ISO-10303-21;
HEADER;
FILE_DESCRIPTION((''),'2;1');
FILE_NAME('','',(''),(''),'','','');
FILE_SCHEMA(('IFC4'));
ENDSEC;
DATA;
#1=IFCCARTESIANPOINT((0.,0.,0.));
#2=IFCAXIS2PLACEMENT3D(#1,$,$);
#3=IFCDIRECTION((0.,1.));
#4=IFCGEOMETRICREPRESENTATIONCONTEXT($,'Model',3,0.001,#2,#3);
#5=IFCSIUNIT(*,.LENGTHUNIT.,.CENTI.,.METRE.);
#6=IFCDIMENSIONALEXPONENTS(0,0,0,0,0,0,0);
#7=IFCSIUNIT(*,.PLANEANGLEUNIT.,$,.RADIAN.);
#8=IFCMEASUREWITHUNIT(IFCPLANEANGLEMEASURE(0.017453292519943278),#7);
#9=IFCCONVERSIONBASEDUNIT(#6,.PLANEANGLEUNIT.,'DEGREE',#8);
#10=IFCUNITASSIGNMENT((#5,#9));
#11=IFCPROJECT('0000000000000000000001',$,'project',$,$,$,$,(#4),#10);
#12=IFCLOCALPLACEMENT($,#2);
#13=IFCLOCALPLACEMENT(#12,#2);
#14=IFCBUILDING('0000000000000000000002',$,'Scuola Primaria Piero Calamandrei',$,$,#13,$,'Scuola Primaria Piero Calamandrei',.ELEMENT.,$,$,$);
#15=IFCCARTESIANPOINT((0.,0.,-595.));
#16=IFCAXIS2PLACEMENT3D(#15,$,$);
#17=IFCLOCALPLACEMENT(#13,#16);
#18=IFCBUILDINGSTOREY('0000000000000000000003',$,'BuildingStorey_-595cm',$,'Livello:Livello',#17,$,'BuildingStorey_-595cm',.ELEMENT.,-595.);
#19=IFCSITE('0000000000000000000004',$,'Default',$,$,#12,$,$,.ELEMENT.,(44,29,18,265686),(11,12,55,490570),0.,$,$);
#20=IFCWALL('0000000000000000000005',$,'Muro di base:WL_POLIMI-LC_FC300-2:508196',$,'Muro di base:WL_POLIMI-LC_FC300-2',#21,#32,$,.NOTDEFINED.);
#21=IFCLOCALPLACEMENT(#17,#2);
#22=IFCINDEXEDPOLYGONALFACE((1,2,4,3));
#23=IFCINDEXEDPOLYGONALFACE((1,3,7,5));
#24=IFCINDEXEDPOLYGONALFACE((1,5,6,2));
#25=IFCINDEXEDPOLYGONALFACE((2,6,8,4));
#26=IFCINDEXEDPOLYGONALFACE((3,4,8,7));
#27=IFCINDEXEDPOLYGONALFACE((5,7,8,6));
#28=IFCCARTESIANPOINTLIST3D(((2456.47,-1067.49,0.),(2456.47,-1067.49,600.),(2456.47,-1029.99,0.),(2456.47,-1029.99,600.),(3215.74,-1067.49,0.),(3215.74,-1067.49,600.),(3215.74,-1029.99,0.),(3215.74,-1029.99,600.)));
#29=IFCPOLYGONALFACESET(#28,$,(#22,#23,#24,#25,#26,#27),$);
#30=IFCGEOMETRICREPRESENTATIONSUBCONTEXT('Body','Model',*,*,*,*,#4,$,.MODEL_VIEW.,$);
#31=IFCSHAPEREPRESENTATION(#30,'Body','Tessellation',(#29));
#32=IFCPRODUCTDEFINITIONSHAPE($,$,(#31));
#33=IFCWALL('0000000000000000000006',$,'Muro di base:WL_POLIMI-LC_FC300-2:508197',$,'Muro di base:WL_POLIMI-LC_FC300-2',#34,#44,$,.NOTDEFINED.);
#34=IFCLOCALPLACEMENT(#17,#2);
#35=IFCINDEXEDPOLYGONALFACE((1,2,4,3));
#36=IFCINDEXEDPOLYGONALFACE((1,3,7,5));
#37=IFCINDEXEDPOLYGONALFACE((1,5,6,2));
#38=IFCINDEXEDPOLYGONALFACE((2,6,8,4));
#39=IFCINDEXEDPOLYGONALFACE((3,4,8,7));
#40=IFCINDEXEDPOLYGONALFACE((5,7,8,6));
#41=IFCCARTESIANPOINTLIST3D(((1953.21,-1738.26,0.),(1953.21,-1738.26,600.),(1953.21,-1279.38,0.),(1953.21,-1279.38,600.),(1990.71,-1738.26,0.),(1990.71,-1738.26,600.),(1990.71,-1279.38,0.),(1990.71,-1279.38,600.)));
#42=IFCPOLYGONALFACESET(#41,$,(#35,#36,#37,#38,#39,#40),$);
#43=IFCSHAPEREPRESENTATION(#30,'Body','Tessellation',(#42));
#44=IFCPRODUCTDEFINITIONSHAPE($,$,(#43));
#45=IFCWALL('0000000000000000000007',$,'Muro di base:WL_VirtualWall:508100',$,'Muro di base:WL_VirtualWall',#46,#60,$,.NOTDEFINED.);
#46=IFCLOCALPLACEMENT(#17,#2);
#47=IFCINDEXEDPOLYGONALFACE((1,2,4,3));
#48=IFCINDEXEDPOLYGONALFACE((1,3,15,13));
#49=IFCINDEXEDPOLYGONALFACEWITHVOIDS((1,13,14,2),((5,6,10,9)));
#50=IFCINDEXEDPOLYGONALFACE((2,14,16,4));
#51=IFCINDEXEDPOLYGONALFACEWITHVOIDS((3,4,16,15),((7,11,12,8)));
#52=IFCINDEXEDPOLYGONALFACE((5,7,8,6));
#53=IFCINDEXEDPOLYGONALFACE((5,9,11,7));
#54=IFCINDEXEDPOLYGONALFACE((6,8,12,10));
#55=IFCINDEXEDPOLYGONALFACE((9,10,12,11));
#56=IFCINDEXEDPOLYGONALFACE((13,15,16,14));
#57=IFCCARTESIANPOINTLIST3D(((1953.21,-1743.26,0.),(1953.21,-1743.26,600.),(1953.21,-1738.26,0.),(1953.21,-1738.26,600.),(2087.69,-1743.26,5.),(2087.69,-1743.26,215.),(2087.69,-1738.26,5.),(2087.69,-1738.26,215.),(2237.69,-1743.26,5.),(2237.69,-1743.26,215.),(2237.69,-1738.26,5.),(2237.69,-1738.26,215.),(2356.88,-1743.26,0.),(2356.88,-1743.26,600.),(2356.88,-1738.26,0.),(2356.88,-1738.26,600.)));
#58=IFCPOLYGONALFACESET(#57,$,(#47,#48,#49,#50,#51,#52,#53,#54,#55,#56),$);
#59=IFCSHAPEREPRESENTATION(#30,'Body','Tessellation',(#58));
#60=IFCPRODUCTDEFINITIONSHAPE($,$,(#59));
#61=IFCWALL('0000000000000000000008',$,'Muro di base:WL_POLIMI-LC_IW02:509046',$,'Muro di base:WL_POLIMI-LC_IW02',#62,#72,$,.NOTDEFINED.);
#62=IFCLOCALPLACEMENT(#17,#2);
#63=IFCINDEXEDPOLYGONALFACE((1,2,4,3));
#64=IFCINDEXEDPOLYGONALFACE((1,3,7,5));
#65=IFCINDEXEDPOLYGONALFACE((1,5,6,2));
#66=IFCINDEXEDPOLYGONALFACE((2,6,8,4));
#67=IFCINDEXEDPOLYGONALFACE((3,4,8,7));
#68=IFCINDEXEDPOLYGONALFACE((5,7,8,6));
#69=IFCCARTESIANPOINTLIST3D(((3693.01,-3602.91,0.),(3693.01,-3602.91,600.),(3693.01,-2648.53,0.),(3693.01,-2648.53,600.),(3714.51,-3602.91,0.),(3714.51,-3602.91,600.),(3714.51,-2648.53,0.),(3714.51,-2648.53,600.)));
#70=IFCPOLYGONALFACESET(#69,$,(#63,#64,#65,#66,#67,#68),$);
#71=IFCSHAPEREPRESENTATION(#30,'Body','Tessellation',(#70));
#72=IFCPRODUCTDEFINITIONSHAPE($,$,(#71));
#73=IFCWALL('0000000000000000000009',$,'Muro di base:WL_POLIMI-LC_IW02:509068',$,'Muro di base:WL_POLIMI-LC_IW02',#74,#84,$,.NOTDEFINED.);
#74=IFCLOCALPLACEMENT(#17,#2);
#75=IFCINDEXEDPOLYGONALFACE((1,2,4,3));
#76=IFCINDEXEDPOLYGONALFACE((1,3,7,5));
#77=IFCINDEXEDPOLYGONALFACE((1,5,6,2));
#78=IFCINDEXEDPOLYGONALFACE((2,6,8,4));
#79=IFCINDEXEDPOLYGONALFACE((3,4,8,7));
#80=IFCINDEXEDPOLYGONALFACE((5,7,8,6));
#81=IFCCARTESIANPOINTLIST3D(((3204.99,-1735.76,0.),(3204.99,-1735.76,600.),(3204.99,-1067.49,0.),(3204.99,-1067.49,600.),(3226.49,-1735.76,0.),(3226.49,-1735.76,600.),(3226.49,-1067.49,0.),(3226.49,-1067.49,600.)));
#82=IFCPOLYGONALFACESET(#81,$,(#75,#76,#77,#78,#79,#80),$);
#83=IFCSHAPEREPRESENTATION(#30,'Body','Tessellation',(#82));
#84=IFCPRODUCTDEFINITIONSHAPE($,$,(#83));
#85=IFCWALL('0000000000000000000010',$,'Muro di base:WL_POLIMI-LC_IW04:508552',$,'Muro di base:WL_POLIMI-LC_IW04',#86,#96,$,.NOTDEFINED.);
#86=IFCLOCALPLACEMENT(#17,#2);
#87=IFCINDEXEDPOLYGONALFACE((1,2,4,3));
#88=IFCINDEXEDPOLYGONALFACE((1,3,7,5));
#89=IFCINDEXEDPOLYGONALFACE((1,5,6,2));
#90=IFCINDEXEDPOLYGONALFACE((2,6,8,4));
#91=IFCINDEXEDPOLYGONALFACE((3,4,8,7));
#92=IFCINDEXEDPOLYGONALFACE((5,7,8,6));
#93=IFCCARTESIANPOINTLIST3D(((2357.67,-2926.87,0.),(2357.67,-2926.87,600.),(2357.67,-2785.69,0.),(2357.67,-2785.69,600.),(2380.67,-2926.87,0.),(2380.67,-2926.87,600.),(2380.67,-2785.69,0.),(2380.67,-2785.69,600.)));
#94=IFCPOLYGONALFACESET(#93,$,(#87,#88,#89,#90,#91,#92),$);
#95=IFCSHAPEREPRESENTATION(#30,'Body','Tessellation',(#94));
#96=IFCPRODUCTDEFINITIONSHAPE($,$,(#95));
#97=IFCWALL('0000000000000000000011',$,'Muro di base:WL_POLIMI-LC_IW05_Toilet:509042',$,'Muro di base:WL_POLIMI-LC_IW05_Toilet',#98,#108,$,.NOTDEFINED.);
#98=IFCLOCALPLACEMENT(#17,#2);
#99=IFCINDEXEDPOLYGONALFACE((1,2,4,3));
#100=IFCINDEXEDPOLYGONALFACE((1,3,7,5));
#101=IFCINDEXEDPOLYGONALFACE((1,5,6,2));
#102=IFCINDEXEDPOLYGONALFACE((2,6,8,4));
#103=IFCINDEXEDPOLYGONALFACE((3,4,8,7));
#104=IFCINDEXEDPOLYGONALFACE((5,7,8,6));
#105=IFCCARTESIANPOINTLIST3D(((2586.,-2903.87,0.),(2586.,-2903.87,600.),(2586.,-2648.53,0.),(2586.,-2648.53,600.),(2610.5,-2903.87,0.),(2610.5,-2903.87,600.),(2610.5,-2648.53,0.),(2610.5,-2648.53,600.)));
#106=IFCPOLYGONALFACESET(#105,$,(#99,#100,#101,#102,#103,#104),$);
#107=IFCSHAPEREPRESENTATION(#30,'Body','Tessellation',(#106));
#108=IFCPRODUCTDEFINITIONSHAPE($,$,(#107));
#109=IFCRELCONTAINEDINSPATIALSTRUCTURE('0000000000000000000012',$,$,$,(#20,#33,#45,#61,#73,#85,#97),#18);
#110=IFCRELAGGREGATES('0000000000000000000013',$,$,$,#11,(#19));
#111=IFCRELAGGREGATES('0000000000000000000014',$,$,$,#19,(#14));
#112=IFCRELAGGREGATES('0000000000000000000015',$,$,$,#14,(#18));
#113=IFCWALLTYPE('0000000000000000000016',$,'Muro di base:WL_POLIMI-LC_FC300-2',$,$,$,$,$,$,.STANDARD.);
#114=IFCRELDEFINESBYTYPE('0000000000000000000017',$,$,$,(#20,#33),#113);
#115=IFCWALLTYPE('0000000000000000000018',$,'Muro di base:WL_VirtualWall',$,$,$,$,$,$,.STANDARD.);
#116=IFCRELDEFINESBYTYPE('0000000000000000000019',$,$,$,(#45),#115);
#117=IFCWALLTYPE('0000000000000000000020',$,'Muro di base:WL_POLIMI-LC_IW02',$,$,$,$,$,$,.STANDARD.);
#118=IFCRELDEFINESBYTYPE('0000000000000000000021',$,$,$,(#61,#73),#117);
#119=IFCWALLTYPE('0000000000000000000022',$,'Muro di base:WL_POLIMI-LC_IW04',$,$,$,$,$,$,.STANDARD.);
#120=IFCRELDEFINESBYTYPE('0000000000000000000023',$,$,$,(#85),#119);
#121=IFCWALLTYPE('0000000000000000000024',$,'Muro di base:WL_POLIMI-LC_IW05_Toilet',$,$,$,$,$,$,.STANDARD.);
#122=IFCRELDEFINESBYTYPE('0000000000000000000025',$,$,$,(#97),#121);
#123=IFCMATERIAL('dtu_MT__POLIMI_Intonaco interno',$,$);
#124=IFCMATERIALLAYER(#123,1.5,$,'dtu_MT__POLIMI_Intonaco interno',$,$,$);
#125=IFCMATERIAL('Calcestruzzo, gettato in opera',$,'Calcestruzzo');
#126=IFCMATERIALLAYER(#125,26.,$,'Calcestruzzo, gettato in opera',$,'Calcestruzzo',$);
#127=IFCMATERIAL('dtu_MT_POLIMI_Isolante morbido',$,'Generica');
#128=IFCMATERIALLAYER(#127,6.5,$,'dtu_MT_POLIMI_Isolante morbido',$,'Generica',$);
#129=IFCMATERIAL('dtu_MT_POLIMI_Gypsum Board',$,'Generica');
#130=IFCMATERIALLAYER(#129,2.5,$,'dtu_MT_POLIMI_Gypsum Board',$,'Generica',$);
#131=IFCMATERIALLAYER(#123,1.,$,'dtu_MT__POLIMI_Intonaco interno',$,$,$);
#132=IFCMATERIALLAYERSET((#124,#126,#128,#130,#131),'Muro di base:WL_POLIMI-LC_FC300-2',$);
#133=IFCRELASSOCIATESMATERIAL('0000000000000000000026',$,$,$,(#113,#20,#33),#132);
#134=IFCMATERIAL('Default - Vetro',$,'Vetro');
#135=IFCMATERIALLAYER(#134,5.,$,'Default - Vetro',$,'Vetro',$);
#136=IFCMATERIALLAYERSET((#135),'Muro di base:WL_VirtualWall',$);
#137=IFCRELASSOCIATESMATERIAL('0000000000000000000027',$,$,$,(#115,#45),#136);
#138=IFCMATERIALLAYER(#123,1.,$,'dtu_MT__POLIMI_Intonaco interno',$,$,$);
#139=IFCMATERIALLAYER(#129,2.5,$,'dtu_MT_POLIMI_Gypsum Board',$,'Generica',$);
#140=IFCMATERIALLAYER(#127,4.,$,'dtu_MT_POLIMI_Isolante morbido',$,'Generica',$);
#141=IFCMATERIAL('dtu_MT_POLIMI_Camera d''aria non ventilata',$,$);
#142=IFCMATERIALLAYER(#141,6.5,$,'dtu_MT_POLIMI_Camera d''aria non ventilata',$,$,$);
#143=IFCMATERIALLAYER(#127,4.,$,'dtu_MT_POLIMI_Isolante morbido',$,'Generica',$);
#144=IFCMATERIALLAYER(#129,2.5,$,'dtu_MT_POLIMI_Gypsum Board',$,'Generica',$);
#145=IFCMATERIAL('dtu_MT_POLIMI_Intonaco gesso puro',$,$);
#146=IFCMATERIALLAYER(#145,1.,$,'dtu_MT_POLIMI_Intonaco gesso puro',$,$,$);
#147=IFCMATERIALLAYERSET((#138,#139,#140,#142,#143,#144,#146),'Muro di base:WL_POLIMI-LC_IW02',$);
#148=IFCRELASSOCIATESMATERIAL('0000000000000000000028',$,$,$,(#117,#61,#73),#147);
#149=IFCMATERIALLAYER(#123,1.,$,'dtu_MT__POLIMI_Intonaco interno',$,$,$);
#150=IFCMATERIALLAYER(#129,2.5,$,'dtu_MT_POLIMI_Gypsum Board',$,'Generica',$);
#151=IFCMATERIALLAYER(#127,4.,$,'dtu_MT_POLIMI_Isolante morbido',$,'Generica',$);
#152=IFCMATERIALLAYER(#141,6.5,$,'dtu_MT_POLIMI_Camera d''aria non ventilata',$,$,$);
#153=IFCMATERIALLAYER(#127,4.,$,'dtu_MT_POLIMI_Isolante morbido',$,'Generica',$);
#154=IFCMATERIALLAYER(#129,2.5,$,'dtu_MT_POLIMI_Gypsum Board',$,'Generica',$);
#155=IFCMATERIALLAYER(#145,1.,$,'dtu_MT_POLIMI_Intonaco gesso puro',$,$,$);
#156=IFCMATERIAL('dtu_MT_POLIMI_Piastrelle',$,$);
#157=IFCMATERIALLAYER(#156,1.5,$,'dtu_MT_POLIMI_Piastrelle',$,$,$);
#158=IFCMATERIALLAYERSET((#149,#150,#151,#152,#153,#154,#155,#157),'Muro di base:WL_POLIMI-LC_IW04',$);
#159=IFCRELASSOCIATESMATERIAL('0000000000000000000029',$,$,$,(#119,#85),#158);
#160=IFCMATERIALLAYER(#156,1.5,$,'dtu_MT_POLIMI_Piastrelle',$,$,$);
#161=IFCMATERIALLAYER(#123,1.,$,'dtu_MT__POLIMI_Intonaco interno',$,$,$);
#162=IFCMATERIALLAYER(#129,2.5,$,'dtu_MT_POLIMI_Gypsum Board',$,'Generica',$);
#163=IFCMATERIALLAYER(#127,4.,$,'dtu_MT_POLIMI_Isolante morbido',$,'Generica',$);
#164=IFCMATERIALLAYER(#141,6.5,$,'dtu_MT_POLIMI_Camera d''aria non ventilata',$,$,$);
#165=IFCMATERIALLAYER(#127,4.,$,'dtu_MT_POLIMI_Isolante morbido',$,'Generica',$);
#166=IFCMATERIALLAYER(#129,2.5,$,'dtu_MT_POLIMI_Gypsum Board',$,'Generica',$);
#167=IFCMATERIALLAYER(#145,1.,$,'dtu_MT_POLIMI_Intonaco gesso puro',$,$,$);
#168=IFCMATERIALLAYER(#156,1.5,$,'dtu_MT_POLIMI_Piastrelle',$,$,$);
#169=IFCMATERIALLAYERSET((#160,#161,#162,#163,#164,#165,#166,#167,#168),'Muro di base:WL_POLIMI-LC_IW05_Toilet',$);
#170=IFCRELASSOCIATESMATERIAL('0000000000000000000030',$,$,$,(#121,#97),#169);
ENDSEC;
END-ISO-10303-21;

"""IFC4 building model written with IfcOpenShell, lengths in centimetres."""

from ifc_helpers import new_model, entity, si_unit, converted_unit, direction, frame, frame_2d, origin, place, context, subcontext, project, spatial, rectangle, extrude, material, layer, layer_set, layer_usage, type_object, element, save


model = new_model("IFC4")

# Units and contexts
model_context = context("Model", 3, precision=0.001, world=origin(), true_north=direction((0.0, 1.0)))
body_context = subcontext(model_context, "Body", "Model", "MODEL_VIEW")
ifc_project = project(units=[si_unit("LENGTHUNIT", "METRE", prefix="CENTI"), converted_unit("PLANEANGLEUNIT", "DEGREE", entity("IfcPlaneAngleMeasure", 0.017453292519943278), si_unit("PLANEANGLEUNIT", "RADIAN"), dimensions=[0, 0, 0, 0, 0, 0, 0])], contexts=[model_context])

# Site, building, storey
site_placement = place(None, origin())
site = spatial("IfcSite", under=ifc_project, at=site_placement, Name="Default", CompositionType="ELEMENT", RefLatitude=(44, 29, 18, 265686), RefLongitude=(11, 12, 55, 490570), RefElevation=0.0)
building_placement = place(site_placement, origin())
building = spatial("IfcBuilding", under=site, at=building_placement, Name="Scuola Primaria Piero Calamandrei", LongName="Scuola Primaria Piero Calamandrei", CompositionType="ELEMENT")
storey_placement = place(building_placement, frame((0.0, 0.0, -595.0)))
storey = spatial("IfcBuildingStorey", under=building, at=storey_placement, Name="BuildingStorey_-595cm", ObjectType="Livello:Livello", LongName="BuildingStorey_-595cm", CompositionType="ELEMENT", Elevation=-595.0)

# Shared definitions
ifc_material_1 = material(Name="Default - Vetro", Category="Vetro")

# Walls
ifc_material_2 = material(Name="dtu_MT__POLIMI_Intonaco interno")
ifc_layer_1 = layer(ifc_material_2, 1.5, Name="dtu_MT__POLIMI_Intonaco interno")
ifc_material_3 = material(Name="Calcestruzzo, gettato in opera", Category="Calcestruzzo")
ifc_layer_2 = layer(ifc_material_3, 26.0, Name="Calcestruzzo, gettato in opera", Category="Calcestruzzo")
ifc_material_4 = material(Name="dtu_MT_POLIMI_Isolante morbido", Category="Generica")
ifc_layer_3 = layer(ifc_material_4, 6.5, Name="dtu_MT_POLIMI_Isolante morbido", Category="Generica")
ifc_material_5 = material(Name="dtu_MT_POLIMI_Gypsum Board", Category="Generica")
ifc_layer_4 = layer(ifc_material_5, 2.5, Name="dtu_MT_POLIMI_Gypsum Board", Category="Generica")
ifc_layer_5 = layer(ifc_material_2, 1.0, Name="dtu_MT__POLIMI_Intonaco interno")
ifc_layer_set_1 = layer_set([ifc_layer_1, ifc_layer_2, ifc_layer_3, ifc_layer_4, ifc_layer_5], Name="Muro di base:WL_POLIMI-LC_FC300-2")
wall_type_1 = type_object("IfcWallType", Name="Muro di base:WL_POLIMI-LC_FC300-2", PredefinedType="STANDARD", material=ifc_layer_set_1)
ifc_layer_usage_1 = layer_usage(ifc_layer_set_1, "AXIS2", "NEGATIVE", 18.75)
wall_1_placement = place(storey_placement, frame((2456.47, -1048.74, 0.0)))
element("IfcWall", 1, at=wall_1_placement, inside=storey, type_object=wall_type_1, material=ifc_layer_usage_1, Name="Muro di base:WL_POLIMI-LC_FC300-2:508196", ObjectType="Muro di base:WL_POLIMI-LC_FC300-2", PredefinedType="NOTDEFINED", context=body_context, shape_type="SweptSolid", body=[
    extrude(rectangle(XDim=759.27, YDim=37.5, at=frame_2d((379.63, 0.0), x_axis=(-1.0, 0.0))), origin(), (0.0, 0.0, 1.0), 600.0),
])
ifc_layer_usage_2 = layer_usage(ifc_layer_set_1, "AXIS2", "NEGATIVE", 18.75)
wall_2_placement = place(storey_placement, frame((1971.96, -1279.38, 0.0), z_axis=(0.0, 0.0, 1.0), x_axis=(0.0, -1.0, 0.0)))
element("IfcWall", 2, at=wall_2_placement, inside=storey, type_object=wall_type_1, material=ifc_layer_usage_2, Name="Muro di base:WL_POLIMI-LC_FC300-2:508197", ObjectType="Muro di base:WL_POLIMI-LC_FC300-2", PredefinedType="NOTDEFINED", context=body_context, shape_type="SweptSolid", body=[
    extrude(rectangle(XDim=458.88, YDim=37.5, at=frame_2d((229.44, 0.0), x_axis=(-1.0, 0.0))), origin(), (0.0, 0.0, 1.0), 600.0),
])

# Wall, opening
ifc_layer_6 = layer(ifc_material_1, 5.0, Name="Default - Vetro", Category="Vetro")
ifc_layer_set_2 = layer_set([ifc_layer_6], Name="Muro di base:WL_VirtualWall")
ifc_layer_usage_3 = layer_usage(ifc_layer_set_2, "AXIS2", "NEGATIVE", 2.5)
wall_type_2 = type_object("IfcWallType", Name="Muro di base:WL_VirtualWall", PredefinedType="STANDARD", material=ifc_layer_set_2)
wall_3_placement = place(storey_placement, frame((1953.21, -1740.76, 0.0)))
wall_3 = element("IfcWall", 3, at=wall_3_placement, inside=storey, type_object=wall_type_2, material=ifc_layer_usage_3, Name="Muro di base:WL_VirtualWall:508100", ObjectType="Muro di base:WL_VirtualWall", PredefinedType="NOTDEFINED", context=body_context, shape_type="SweptSolid", body=[
    extrude(rectangle(XDim=403.67, YDim=5.0, at=frame_2d((201.83, 0.0), x_axis=(-1.0, 0.0))), origin(), (0.0, 0.0, 1.0), 600.0),
])
opening_1_placement = place(wall_3_placement, frame((284.48, 2.5, 5.0)))
element("IfcOpeningElement", 4, at=opening_1_placement, cuts=wall_3, PredefinedType="OPENING", context=body_context, shape_type="SweptSolid", body=[
    extrude(rectangle(XDim=210.0, YDim=150.0, at=frame_2d((105.0, 75.0), x_axis=(-1.0, 0.0))), frame((0.0, 0.0, 0.0), z_axis=(0.0, -1.0, 0.0), x_axis=(0.0, 0.0, 1.0)), (0.0, 0.0, 1.0), 5.0),
])

# Walls
ifc_layer_7 = layer(ifc_material_2, 1.0, Name="dtu_MT__POLIMI_Intonaco interno")
ifc_layer_8 = layer(ifc_material_5, 2.5, Name="dtu_MT_POLIMI_Gypsum Board", Category="Generica")
ifc_layer_9 = layer(ifc_material_4, 4.0, Name="dtu_MT_POLIMI_Isolante morbido", Category="Generica")
ifc_material_6 = material(Name="dtu_MT_POLIMI_Camera d'aria non ventilata")
ifc_layer_10 = layer(ifc_material_6, 6.5, Name="dtu_MT_POLIMI_Camera d'aria non ventilata")
ifc_layer_11 = layer(ifc_material_4, 4.0, Name="dtu_MT_POLIMI_Isolante morbido", Category="Generica")
ifc_layer_12 = layer(ifc_material_5, 2.5, Name="dtu_MT_POLIMI_Gypsum Board", Category="Generica")
ifc_material_7 = material(Name="dtu_MT_POLIMI_Intonaco gesso puro")
ifc_layer_13 = layer(ifc_material_7, 1.0, Name="dtu_MT_POLIMI_Intonaco gesso puro")
ifc_layer_set_3 = layer_set([ifc_layer_7, ifc_layer_8, ifc_layer_9, ifc_layer_10, ifc_layer_11, ifc_layer_12, ifc_layer_13], Name="Muro di base:WL_POLIMI-LC_IW02")
ifc_layer_usage_4 = layer_usage(ifc_layer_set_3, "AXIS2", "NEGATIVE", 10.75)
wall_type_3 = type_object("IfcWallType", Name="Muro di base:WL_POLIMI-LC_IW02", PredefinedType="STANDARD", material=ifc_layer_set_3)
wall_4_placement = place(storey_placement, frame((3703.76, -2648.53, 0.0), z_axis=(0.0, 0.0, 1.0), x_axis=(0.0, -1.0, 0.0)))
element("IfcWall", 5, at=wall_4_placement, inside=storey, type_object=wall_type_3, material=ifc_layer_usage_4, Name="Muro di base:WL_POLIMI-LC_IW02:509046", ObjectType="Muro di base:WL_POLIMI-LC_IW02", PredefinedType="NOTDEFINED", context=body_context, shape_type="SweptSolid", body=[
    extrude(rectangle(XDim=954.38, YDim=21.5, at=frame_2d((477.19, 0.0), x_axis=(-1.0, 0.0))), origin(), (0.0, 0.0, 1.0), 600.0),
])
ifc_layer_usage_5 = layer_usage(ifc_layer_set_3, "AXIS2", "NEGATIVE", 10.75)
wall_5_placement = place(storey_placement, frame((3215.74, -1735.76, 0.0), z_axis=(0.0, 0.0, 1.0), x_axis=(0.0, 1.0, 0.0)))
element("IfcWall", 6, at=wall_5_placement, inside=storey, type_object=wall_type_3, material=ifc_layer_usage_5, Name="Muro di base:WL_POLIMI-LC_IW02:509068", ObjectType="Muro di base:WL_POLIMI-LC_IW02", PredefinedType="NOTDEFINED", context=body_context, shape_type="SweptSolid", body=[
    extrude(rectangle(XDim=668.26, YDim=21.5, at=frame_2d((334.13, 0.0), x_axis=(-1.0, 0.0))), origin(), (0.0, 0.0, 1.0), 600.0),
])
ifc_layer_14 = layer(ifc_material_2, 1.0, Name="dtu_MT__POLIMI_Intonaco interno")
ifc_layer_15 = layer(ifc_material_5, 2.5, Name="dtu_MT_POLIMI_Gypsum Board", Category="Generica")
ifc_layer_16 = layer(ifc_material_4, 4.0, Name="dtu_MT_POLIMI_Isolante morbido", Category="Generica")
ifc_layer_17 = layer(ifc_material_6, 6.5, Name="dtu_MT_POLIMI_Camera d'aria non ventilata")
ifc_layer_18 = layer(ifc_material_4, 4.0, Name="dtu_MT_POLIMI_Isolante morbido", Category="Generica")
ifc_layer_19 = layer(ifc_material_5, 2.5, Name="dtu_MT_POLIMI_Gypsum Board", Category="Generica")
ifc_layer_20 = layer(ifc_material_7, 1.0, Name="dtu_MT_POLIMI_Intonaco gesso puro")
ifc_material_8 = material(Name="dtu_MT_POLIMI_Piastrelle")
ifc_layer_21 = layer(ifc_material_8, 1.5, Name="dtu_MT_POLIMI_Piastrelle")
ifc_layer_set_4 = layer_set([ifc_layer_14, ifc_layer_15, ifc_layer_16, ifc_layer_17, ifc_layer_18, ifc_layer_19, ifc_layer_20, ifc_layer_21], Name="Muro di base:WL_POLIMI-LC_IW04")
ifc_layer_usage_6 = layer_usage(ifc_layer_set_4, "AXIS2", "NEGATIVE", 11.5)
wall_type_4 = type_object("IfcWallType", Name="Muro di base:WL_POLIMI-LC_IW04", PredefinedType="STANDARD", material=ifc_layer_set_4)
wall_6_placement = place(storey_placement, frame((2369.17, -2785.69, 0.0), z_axis=(0.0, 0.0, 1.0), x_axis=(0.0, -1.0, 0.0)))
element("IfcWall", 7, at=wall_6_placement, inside=storey, type_object=wall_type_4, material=ifc_layer_usage_6, Name="Muro di base:WL_POLIMI-LC_IW04:508552", ObjectType="Muro di base:WL_POLIMI-LC_IW04", PredefinedType="NOTDEFINED", context=body_context, shape_type="SweptSolid", body=[
    extrude(rectangle(XDim=141.18, YDim=23.0, at=frame_2d((70.59, 0.0), x_axis=(-1.0, 0.0))), origin(), (0.0, 0.0, 1.0), 600.0),
])
ifc_layer_22 = layer(ifc_material_8, 1.5, Name="dtu_MT_POLIMI_Piastrelle")
ifc_layer_23 = layer(ifc_material_2, 1.0, Name="dtu_MT__POLIMI_Intonaco interno")
ifc_layer_24 = layer(ifc_material_5, 2.5, Name="dtu_MT_POLIMI_Gypsum Board", Category="Generica")
ifc_layer_25 = layer(ifc_material_4, 4.0, Name="dtu_MT_POLIMI_Isolante morbido", Category="Generica")
ifc_layer_26 = layer(ifc_material_6, 6.5, Name="dtu_MT_POLIMI_Camera d'aria non ventilata")
ifc_layer_27 = layer(ifc_material_4, 4.0, Name="dtu_MT_POLIMI_Isolante morbido", Category="Generica")
ifc_layer_28 = layer(ifc_material_5, 2.5, Name="dtu_MT_POLIMI_Gypsum Board", Category="Generica")
ifc_layer_29 = layer(ifc_material_7, 1.0, Name="dtu_MT_POLIMI_Intonaco gesso puro")
ifc_layer_30 = layer(ifc_material_8, 1.5, Name="dtu_MT_POLIMI_Piastrelle")
ifc_layer_set_5 = layer_set([ifc_layer_22, ifc_layer_23, ifc_layer_24, ifc_layer_25, ifc_layer_26, ifc_layer_27, ifc_layer_28, ifc_layer_29, ifc_layer_30], Name="Muro di base:WL_POLIMI-LC_IW05_Toilet")
ifc_layer_usage_7 = layer_usage(ifc_layer_set_5, "AXIS2", "NEGATIVE", 12.25)
wall_type_5 = type_object("IfcWallType", Name="Muro di base:WL_POLIMI-LC_IW05_Toilet", PredefinedType="STANDARD", material=ifc_layer_set_5)
wall_7_placement = place(storey_placement, frame((2598.25, -2648.53, 0.0), z_axis=(0.0, 0.0, 1.0), x_axis=(0.0, -1.0, 0.0)))
element("IfcWall", 8, at=wall_7_placement, inside=storey, type_object=wall_type_5, material=ifc_layer_usage_7, Name="Muro di base:WL_POLIMI-LC_IW05_Toilet:509042", ObjectType="Muro di base:WL_POLIMI-LC_IW05_Toilet", PredefinedType="NOTDEFINED", context=body_context, shape_type="SweptSolid", body=[
    extrude(rectangle(XDim=255.34, YDim=24.5, at=frame_2d((127.67, 0.0), x_axis=(-1.0, 0.0))), origin(), (0.0, 0.0, 1.0), 600.0),
])

save(model, "model.ifc")
